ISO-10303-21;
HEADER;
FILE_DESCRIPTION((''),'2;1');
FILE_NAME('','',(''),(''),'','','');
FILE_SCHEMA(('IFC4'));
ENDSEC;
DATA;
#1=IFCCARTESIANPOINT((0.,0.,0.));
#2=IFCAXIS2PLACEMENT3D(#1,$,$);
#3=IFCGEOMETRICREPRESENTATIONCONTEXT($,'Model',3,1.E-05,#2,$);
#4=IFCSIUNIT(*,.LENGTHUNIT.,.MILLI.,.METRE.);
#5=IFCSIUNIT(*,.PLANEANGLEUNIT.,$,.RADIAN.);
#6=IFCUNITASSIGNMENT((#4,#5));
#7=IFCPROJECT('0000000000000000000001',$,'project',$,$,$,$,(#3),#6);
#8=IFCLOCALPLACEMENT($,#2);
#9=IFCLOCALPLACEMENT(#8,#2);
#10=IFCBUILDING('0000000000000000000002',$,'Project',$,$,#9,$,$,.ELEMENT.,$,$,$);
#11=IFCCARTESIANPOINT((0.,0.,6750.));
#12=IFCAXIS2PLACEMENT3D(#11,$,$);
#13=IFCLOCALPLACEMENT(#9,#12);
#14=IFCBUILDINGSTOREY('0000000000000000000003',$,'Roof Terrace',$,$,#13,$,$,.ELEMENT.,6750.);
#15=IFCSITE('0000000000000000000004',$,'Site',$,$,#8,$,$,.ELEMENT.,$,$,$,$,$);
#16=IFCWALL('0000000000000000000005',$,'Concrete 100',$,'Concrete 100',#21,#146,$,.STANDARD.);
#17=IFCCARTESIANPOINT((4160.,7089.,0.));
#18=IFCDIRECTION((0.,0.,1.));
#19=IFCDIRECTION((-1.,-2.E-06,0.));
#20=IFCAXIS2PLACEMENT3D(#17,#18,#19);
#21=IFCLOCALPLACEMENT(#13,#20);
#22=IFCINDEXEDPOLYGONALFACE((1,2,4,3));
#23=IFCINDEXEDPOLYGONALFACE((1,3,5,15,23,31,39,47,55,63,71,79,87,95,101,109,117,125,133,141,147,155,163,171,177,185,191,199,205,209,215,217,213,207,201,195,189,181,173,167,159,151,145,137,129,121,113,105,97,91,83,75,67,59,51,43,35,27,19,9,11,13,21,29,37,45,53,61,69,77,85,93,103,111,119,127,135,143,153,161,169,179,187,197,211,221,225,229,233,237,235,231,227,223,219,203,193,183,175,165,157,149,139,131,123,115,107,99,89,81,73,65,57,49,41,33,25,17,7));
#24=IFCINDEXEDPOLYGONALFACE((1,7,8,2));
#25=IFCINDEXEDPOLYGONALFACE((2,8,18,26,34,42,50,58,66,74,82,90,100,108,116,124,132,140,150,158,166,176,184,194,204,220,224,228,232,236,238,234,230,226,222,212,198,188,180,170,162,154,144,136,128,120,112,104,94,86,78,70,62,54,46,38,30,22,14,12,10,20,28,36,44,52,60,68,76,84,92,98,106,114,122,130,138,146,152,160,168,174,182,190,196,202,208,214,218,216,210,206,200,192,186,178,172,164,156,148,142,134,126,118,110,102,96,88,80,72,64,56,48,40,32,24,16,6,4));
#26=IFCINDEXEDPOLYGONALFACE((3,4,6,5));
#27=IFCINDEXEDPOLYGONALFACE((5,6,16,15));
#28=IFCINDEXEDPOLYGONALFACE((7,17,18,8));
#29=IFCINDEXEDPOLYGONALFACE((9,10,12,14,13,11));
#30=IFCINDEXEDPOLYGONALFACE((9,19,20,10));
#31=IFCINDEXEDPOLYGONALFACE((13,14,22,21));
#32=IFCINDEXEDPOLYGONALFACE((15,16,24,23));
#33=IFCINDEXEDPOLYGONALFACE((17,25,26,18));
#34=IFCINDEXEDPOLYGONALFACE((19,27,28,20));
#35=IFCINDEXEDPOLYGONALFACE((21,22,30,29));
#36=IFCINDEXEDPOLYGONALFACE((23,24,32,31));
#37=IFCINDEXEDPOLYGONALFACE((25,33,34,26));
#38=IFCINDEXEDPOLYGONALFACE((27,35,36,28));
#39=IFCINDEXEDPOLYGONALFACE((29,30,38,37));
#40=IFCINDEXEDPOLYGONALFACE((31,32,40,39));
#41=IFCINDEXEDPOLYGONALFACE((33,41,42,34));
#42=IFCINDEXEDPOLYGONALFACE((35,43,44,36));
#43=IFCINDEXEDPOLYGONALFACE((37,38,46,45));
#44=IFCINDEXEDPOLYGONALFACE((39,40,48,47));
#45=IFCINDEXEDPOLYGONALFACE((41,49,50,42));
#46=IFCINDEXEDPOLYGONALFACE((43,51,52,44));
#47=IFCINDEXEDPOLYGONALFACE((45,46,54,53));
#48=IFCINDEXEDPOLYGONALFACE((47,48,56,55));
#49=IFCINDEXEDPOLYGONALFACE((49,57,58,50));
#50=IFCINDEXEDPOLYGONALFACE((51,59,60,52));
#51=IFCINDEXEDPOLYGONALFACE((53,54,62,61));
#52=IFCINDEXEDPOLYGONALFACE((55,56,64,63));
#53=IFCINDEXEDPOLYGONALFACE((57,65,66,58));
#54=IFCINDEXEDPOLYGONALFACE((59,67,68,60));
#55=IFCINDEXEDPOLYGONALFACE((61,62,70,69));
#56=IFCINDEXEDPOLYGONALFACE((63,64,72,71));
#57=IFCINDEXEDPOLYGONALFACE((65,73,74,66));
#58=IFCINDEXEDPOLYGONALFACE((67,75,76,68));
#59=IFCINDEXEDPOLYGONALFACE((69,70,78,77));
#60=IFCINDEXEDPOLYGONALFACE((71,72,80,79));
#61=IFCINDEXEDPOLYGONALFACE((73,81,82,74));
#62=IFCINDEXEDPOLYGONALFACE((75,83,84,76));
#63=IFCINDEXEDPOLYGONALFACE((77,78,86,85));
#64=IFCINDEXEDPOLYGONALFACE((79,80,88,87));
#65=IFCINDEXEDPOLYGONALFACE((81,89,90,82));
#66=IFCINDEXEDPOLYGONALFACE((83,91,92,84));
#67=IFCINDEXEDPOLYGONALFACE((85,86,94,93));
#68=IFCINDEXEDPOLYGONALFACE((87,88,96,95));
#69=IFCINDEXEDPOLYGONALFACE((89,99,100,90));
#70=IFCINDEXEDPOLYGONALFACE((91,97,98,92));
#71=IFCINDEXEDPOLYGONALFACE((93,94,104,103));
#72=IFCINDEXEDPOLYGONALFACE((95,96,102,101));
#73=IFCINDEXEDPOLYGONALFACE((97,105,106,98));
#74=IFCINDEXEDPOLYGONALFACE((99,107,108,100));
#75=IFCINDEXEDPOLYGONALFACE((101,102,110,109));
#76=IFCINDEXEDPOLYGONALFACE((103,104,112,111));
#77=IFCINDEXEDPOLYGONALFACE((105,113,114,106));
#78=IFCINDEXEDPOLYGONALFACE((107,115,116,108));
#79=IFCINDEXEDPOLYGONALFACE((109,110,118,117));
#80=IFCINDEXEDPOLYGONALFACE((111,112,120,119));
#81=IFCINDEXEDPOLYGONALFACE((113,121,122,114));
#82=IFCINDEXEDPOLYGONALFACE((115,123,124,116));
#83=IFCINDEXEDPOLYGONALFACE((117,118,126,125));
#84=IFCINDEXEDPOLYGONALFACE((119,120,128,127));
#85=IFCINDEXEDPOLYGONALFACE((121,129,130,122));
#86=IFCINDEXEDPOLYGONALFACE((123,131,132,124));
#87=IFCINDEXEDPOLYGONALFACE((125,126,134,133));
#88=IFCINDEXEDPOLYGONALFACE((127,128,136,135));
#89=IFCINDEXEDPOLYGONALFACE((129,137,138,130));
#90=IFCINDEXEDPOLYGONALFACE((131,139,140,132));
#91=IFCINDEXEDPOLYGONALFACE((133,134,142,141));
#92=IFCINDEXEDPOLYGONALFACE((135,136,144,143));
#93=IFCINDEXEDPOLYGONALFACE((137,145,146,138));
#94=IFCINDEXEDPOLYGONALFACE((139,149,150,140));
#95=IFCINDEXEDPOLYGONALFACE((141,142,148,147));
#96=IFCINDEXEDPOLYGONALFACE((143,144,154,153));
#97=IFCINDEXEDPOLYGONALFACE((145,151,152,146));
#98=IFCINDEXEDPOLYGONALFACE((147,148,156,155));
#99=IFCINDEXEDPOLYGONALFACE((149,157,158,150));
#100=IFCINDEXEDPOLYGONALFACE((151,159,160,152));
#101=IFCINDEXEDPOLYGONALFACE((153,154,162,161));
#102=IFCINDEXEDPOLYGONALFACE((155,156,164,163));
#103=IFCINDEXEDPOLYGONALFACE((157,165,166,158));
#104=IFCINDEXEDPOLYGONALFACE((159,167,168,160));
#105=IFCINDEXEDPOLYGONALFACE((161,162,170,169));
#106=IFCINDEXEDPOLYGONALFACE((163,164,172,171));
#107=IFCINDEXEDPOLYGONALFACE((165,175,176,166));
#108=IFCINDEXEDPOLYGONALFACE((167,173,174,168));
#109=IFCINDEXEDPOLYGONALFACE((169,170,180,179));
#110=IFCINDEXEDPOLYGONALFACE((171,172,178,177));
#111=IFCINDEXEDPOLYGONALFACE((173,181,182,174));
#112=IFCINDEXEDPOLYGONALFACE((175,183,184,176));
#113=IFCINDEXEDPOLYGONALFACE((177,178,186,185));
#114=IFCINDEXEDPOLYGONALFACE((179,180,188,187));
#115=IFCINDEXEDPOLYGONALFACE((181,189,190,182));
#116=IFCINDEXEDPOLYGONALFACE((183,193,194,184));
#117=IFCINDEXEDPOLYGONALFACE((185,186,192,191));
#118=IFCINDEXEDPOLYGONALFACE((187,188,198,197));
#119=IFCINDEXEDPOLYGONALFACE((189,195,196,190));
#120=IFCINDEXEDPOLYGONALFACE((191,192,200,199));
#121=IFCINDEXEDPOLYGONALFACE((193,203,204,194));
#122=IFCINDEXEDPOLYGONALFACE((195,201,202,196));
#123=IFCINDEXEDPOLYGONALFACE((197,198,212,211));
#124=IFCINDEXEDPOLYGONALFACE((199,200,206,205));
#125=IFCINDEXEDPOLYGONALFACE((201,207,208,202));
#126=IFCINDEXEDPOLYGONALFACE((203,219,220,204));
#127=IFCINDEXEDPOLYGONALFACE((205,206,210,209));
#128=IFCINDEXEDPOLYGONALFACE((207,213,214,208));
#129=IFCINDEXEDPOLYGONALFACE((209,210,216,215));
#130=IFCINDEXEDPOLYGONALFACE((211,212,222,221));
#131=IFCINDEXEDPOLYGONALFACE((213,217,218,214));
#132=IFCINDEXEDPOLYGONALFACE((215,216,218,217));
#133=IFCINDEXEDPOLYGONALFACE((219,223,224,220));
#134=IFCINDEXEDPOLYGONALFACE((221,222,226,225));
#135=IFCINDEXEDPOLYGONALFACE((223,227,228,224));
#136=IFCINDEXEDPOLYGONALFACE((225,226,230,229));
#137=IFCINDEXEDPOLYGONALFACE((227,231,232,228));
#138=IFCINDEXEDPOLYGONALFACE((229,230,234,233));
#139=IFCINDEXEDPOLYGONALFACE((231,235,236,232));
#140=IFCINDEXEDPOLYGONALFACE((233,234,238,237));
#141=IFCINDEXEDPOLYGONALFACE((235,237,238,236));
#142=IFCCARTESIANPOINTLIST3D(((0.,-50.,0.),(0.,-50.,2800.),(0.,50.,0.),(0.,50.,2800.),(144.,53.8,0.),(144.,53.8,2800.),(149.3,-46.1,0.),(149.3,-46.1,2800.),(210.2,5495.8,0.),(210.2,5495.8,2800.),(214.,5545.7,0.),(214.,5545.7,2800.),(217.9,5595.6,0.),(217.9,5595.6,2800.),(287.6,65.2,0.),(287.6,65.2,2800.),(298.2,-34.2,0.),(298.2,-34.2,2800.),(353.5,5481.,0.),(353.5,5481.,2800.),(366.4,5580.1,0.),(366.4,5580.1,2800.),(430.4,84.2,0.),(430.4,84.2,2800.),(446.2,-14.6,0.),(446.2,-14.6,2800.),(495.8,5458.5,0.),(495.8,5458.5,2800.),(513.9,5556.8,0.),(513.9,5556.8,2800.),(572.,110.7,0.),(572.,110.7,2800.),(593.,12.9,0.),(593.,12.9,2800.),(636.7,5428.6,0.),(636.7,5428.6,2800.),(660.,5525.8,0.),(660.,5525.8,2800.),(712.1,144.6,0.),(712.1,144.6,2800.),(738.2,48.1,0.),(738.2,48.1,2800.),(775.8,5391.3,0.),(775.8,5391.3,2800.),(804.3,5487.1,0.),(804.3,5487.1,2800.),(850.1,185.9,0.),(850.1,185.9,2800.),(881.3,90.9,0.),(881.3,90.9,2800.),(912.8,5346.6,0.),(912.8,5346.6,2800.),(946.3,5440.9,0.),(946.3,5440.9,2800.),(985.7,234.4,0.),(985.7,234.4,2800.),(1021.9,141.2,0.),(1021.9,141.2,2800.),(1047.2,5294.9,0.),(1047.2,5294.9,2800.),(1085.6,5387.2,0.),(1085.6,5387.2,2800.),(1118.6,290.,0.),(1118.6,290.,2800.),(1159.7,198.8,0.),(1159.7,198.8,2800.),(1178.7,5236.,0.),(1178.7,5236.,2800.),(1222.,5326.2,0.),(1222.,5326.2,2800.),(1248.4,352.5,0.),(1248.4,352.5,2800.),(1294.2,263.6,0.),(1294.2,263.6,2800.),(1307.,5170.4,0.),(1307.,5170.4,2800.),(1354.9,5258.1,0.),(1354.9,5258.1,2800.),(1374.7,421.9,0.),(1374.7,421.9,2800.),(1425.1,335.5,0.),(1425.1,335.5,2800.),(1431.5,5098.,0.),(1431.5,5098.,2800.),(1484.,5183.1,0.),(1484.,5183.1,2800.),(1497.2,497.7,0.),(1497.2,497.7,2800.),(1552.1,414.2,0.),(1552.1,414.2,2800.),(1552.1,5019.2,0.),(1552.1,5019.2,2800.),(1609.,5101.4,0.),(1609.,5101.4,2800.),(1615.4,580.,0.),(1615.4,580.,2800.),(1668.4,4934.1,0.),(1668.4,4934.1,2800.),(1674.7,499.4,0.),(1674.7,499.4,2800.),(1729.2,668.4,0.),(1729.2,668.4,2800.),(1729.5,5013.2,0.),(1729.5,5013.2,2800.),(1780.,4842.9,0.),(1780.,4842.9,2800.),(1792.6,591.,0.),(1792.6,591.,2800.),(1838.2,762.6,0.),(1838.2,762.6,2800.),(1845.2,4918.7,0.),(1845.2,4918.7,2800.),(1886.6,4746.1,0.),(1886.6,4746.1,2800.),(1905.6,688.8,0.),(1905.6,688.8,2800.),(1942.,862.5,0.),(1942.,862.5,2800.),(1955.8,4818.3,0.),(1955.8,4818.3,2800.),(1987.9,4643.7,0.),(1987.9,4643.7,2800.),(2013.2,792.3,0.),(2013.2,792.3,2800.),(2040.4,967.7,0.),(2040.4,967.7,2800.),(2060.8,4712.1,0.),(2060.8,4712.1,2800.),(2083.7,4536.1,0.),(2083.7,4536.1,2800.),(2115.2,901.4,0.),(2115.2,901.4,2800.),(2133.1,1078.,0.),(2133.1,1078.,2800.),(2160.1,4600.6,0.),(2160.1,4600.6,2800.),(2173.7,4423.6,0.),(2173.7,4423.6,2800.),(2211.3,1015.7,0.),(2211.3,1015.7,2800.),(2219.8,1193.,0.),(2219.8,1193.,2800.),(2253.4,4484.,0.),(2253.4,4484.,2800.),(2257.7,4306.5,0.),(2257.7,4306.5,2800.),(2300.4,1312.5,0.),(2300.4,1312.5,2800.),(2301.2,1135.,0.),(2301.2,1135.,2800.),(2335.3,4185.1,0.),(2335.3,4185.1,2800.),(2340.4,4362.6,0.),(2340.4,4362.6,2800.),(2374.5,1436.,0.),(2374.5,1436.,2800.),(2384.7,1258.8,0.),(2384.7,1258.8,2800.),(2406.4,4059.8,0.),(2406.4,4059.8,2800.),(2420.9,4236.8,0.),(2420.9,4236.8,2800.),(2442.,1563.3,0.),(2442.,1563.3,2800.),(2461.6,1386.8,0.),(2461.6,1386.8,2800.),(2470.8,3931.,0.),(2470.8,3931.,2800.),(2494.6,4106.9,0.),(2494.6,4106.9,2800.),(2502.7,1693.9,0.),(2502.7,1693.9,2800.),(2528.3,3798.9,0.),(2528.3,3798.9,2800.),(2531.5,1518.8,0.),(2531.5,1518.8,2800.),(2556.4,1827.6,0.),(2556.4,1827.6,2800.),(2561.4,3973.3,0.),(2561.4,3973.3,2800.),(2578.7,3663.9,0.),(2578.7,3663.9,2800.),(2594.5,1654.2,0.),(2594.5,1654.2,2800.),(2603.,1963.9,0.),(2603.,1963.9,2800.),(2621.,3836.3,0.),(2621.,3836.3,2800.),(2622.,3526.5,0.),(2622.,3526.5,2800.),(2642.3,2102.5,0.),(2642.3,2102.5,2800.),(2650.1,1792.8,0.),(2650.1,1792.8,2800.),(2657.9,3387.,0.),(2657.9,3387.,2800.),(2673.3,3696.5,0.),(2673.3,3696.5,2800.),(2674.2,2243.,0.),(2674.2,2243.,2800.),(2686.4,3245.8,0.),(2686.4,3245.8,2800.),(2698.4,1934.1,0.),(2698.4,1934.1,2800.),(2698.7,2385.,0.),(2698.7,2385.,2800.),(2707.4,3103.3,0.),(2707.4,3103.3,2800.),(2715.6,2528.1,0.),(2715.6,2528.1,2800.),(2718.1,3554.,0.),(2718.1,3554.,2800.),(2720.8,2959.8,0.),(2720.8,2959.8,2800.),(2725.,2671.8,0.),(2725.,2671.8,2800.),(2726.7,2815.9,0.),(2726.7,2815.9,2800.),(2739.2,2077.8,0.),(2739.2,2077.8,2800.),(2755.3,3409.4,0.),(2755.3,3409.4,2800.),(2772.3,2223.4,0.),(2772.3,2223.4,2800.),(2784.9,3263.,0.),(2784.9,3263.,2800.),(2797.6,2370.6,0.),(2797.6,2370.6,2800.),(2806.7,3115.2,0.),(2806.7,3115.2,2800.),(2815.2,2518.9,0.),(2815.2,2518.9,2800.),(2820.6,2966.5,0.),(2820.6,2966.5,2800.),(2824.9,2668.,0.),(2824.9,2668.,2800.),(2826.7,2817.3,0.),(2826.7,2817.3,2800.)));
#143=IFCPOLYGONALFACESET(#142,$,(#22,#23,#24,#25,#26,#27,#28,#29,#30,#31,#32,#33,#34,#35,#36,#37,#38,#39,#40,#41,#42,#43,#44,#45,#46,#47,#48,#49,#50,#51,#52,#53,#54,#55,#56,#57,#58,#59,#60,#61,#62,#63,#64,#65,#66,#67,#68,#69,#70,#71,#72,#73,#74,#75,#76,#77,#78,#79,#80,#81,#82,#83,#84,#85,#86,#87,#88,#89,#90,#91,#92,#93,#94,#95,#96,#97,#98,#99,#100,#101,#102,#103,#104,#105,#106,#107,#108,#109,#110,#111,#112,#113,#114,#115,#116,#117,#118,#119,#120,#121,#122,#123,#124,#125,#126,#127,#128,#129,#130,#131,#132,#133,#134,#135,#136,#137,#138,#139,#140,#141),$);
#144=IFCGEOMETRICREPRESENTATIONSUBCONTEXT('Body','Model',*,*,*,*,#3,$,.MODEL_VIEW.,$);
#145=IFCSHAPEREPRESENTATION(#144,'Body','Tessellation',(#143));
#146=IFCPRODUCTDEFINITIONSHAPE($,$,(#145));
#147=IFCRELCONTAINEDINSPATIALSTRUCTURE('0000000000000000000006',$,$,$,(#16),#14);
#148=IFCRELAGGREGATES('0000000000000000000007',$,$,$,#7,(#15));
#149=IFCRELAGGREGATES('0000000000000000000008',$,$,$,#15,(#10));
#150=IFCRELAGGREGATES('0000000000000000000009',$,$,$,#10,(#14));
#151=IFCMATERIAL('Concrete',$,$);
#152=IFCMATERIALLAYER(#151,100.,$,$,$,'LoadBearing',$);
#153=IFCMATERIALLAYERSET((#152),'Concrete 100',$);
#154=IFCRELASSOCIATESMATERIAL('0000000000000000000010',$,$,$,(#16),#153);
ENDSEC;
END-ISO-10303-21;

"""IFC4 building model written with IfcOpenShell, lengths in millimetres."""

from ifc_helpers import new_model, si_unit, frame, origin, place, context, subcontext, project, spatial, polyline, outline, extrude, material, layer, layer_set, layer_usage, element, save


model = new_model("IFC4")

# Units and contexts
model_context = context("Model", 3, precision=1e-05, world=origin())
body_context = subcontext(model_context, "Body", "Model", "MODEL_VIEW")
ifc_project = project(units=[si_unit("LENGTHUNIT", "METRE", prefix="MILLI"), si_unit("PLANEANGLEUNIT", "RADIAN")], contexts=[model_context])

# Site, building, storey
site_placement = place(None, origin())
site = spatial("IfcSite", under=ifc_project, at=site_placement, Name="Site", CompositionType="ELEMENT")
building_placement = place(site_placement, origin())
building = spatial("IfcBuilding", under=site, at=building_placement, Name="Project", CompositionType="ELEMENT")
storey_placement = place(building_placement, frame((0.0, 0.0, 6750.0)))
storey = spatial("IfcBuildingStorey", under=building, at=storey_placement, Name="Roof Terrace", CompositionType="ELEMENT", Elevation=6750.0)

# Shared definitions
ifc_material = material(Name="Concrete")

# Wall
ifc_layer_1 = layer(ifc_material, 100.0, Category="LoadBearing")
ifc_layer_set_1 = layer_set([ifc_layer_1], Name="Concrete 100")
ifc_layer_usage_1 = layer_usage(ifc_layer_set_1, "AXIS2", "NEGATIVE", 50.0)
wall_1_placement = place(storey_placement, frame((4160.0, 7089.0, 0.0), z_axis=(0.0, 0.0, 1.0), x_axis=(-1.0, -0.000002, 0.0)))
element("IfcWall", 1, at=wall_1_placement, inside=storey, material=ifc_layer_usage_1, Name="Concrete 100", ObjectType="Concrete 100", PredefinedType="STANDARD", context=body_context, shape_type="SweptSolid", body=[
    extrude(outline(polyline([(0.0, -50.0), (0.0, 50.0), (144.0, 53.8), (287.6, 65.2), (430.4, 84.2), (572.0, 110.7), (712.1, 144.6), (850.1, 185.9), (985.7, 234.4), (1118.6, 290.0), (1248.4, 352.5), (1374.7, 421.9), (1497.2, 497.7), (1615.4, 580.0), (1729.2, 668.4), (1838.2, 762.6), (1942.0, 862.5), (2040.4, 967.7), (2133.1, 1078.0), (2219.8, 1193.0), (2300.4, 1312.5), (2374.5, 1436.0), (2442.0, 1563.3), (2502.7, 1693.9), (2556.4, 1827.6), (2603.0, 1963.9), (2642.3, 2102.5), (2674.2, 2243.0), (2698.7, 2385.0), (2715.6, 2528.1), (2725.0, 2671.8), (2726.7, 2815.9), (2720.8, 2959.8), (2707.4, 3103.3), (2686.4, 3245.8), (2657.9, 3387.0), (2622.0, 3526.5), (2578.7, 3663.9), (2528.3, 3798.9), (2470.8, 3931.0), (2406.4, 4059.8), (2335.3, 4185.1), (2257.7, 4306.5), (2173.7, 4423.6), (2083.7, 4536.1), (1987.9, 4643.7), (1886.6, 4746.1), (1780.0, 4842.9), (1668.4, 4934.1), (1552.1, 5019.2), (1431.5, 5098.0), (1307.0, 5170.4), (1178.7, 5236.0), (1047.2, 5294.9), (912.8, 5346.6), (775.8, 5391.3), (636.7, 5428.6), (495.8, 5458.5), (353.5, 5481.0), (210.2, 5495.8), (214.0, 5545.7), (217.9, 5595.6), (366.4, 5580.1), (513.9, 5556.8), (660.0, 5525.8), (804.3, 5487.1), (946.3, 5440.9), (1085.6, 5387.2), (1222.0, 5326.2), (1354.9, 5258.1), (1484.0, 5183.1), (1609.0, 5101.4), (1729.5, 5013.2), (1845.2, 4918.7), (1955.8, 4818.3), (2060.8, 4712.1), (2160.1, 4600.6), (2253.4, 4484.0), (2340.4, 4362.6), (2420.9, 4236.8), (2494.6, 4106.9), (2561.4, 3973.3), (2621.0, 3836.3), (2673.3, 3696.5), (2718.1, 3554.0), (2755.3, 3409.4), (2784.9, 3263.0), (2806.7, 3115.2), (2820.6, 2966.5), (2826.7, 2817.3), (2824.9, 2668.0), (2815.2, 2518.9), (2797.6, 2370.6), (2772.3, 2223.4), (2739.2, 2077.8), (2698.4, 1934.1), (2650.1, 1792.8), (2594.5, 1654.2), (2531.5, 1518.8), (2461.6, 1386.8), (2384.7, 1258.8), (2301.2, 1135.0), (2211.3, 1015.7), (2115.2, 901.4), (2013.2, 792.3), (1905.6, 688.8), (1792.6, 591.0), (1674.7, 499.4), (1552.1, 414.2), (1425.1, 335.5), (1294.2, 263.6), (1159.7, 198.8), (1021.9, 141.2), (881.3, 90.9), (738.2, 48.1), (593.0, 12.9), (446.2, -14.6), (298.2, -34.2), (149.3, -46.1), (0.0, -50.0)])), origin(), (0.0, 0.0, 1.0), 2800.0),
])

save(model, "model.ifc")
